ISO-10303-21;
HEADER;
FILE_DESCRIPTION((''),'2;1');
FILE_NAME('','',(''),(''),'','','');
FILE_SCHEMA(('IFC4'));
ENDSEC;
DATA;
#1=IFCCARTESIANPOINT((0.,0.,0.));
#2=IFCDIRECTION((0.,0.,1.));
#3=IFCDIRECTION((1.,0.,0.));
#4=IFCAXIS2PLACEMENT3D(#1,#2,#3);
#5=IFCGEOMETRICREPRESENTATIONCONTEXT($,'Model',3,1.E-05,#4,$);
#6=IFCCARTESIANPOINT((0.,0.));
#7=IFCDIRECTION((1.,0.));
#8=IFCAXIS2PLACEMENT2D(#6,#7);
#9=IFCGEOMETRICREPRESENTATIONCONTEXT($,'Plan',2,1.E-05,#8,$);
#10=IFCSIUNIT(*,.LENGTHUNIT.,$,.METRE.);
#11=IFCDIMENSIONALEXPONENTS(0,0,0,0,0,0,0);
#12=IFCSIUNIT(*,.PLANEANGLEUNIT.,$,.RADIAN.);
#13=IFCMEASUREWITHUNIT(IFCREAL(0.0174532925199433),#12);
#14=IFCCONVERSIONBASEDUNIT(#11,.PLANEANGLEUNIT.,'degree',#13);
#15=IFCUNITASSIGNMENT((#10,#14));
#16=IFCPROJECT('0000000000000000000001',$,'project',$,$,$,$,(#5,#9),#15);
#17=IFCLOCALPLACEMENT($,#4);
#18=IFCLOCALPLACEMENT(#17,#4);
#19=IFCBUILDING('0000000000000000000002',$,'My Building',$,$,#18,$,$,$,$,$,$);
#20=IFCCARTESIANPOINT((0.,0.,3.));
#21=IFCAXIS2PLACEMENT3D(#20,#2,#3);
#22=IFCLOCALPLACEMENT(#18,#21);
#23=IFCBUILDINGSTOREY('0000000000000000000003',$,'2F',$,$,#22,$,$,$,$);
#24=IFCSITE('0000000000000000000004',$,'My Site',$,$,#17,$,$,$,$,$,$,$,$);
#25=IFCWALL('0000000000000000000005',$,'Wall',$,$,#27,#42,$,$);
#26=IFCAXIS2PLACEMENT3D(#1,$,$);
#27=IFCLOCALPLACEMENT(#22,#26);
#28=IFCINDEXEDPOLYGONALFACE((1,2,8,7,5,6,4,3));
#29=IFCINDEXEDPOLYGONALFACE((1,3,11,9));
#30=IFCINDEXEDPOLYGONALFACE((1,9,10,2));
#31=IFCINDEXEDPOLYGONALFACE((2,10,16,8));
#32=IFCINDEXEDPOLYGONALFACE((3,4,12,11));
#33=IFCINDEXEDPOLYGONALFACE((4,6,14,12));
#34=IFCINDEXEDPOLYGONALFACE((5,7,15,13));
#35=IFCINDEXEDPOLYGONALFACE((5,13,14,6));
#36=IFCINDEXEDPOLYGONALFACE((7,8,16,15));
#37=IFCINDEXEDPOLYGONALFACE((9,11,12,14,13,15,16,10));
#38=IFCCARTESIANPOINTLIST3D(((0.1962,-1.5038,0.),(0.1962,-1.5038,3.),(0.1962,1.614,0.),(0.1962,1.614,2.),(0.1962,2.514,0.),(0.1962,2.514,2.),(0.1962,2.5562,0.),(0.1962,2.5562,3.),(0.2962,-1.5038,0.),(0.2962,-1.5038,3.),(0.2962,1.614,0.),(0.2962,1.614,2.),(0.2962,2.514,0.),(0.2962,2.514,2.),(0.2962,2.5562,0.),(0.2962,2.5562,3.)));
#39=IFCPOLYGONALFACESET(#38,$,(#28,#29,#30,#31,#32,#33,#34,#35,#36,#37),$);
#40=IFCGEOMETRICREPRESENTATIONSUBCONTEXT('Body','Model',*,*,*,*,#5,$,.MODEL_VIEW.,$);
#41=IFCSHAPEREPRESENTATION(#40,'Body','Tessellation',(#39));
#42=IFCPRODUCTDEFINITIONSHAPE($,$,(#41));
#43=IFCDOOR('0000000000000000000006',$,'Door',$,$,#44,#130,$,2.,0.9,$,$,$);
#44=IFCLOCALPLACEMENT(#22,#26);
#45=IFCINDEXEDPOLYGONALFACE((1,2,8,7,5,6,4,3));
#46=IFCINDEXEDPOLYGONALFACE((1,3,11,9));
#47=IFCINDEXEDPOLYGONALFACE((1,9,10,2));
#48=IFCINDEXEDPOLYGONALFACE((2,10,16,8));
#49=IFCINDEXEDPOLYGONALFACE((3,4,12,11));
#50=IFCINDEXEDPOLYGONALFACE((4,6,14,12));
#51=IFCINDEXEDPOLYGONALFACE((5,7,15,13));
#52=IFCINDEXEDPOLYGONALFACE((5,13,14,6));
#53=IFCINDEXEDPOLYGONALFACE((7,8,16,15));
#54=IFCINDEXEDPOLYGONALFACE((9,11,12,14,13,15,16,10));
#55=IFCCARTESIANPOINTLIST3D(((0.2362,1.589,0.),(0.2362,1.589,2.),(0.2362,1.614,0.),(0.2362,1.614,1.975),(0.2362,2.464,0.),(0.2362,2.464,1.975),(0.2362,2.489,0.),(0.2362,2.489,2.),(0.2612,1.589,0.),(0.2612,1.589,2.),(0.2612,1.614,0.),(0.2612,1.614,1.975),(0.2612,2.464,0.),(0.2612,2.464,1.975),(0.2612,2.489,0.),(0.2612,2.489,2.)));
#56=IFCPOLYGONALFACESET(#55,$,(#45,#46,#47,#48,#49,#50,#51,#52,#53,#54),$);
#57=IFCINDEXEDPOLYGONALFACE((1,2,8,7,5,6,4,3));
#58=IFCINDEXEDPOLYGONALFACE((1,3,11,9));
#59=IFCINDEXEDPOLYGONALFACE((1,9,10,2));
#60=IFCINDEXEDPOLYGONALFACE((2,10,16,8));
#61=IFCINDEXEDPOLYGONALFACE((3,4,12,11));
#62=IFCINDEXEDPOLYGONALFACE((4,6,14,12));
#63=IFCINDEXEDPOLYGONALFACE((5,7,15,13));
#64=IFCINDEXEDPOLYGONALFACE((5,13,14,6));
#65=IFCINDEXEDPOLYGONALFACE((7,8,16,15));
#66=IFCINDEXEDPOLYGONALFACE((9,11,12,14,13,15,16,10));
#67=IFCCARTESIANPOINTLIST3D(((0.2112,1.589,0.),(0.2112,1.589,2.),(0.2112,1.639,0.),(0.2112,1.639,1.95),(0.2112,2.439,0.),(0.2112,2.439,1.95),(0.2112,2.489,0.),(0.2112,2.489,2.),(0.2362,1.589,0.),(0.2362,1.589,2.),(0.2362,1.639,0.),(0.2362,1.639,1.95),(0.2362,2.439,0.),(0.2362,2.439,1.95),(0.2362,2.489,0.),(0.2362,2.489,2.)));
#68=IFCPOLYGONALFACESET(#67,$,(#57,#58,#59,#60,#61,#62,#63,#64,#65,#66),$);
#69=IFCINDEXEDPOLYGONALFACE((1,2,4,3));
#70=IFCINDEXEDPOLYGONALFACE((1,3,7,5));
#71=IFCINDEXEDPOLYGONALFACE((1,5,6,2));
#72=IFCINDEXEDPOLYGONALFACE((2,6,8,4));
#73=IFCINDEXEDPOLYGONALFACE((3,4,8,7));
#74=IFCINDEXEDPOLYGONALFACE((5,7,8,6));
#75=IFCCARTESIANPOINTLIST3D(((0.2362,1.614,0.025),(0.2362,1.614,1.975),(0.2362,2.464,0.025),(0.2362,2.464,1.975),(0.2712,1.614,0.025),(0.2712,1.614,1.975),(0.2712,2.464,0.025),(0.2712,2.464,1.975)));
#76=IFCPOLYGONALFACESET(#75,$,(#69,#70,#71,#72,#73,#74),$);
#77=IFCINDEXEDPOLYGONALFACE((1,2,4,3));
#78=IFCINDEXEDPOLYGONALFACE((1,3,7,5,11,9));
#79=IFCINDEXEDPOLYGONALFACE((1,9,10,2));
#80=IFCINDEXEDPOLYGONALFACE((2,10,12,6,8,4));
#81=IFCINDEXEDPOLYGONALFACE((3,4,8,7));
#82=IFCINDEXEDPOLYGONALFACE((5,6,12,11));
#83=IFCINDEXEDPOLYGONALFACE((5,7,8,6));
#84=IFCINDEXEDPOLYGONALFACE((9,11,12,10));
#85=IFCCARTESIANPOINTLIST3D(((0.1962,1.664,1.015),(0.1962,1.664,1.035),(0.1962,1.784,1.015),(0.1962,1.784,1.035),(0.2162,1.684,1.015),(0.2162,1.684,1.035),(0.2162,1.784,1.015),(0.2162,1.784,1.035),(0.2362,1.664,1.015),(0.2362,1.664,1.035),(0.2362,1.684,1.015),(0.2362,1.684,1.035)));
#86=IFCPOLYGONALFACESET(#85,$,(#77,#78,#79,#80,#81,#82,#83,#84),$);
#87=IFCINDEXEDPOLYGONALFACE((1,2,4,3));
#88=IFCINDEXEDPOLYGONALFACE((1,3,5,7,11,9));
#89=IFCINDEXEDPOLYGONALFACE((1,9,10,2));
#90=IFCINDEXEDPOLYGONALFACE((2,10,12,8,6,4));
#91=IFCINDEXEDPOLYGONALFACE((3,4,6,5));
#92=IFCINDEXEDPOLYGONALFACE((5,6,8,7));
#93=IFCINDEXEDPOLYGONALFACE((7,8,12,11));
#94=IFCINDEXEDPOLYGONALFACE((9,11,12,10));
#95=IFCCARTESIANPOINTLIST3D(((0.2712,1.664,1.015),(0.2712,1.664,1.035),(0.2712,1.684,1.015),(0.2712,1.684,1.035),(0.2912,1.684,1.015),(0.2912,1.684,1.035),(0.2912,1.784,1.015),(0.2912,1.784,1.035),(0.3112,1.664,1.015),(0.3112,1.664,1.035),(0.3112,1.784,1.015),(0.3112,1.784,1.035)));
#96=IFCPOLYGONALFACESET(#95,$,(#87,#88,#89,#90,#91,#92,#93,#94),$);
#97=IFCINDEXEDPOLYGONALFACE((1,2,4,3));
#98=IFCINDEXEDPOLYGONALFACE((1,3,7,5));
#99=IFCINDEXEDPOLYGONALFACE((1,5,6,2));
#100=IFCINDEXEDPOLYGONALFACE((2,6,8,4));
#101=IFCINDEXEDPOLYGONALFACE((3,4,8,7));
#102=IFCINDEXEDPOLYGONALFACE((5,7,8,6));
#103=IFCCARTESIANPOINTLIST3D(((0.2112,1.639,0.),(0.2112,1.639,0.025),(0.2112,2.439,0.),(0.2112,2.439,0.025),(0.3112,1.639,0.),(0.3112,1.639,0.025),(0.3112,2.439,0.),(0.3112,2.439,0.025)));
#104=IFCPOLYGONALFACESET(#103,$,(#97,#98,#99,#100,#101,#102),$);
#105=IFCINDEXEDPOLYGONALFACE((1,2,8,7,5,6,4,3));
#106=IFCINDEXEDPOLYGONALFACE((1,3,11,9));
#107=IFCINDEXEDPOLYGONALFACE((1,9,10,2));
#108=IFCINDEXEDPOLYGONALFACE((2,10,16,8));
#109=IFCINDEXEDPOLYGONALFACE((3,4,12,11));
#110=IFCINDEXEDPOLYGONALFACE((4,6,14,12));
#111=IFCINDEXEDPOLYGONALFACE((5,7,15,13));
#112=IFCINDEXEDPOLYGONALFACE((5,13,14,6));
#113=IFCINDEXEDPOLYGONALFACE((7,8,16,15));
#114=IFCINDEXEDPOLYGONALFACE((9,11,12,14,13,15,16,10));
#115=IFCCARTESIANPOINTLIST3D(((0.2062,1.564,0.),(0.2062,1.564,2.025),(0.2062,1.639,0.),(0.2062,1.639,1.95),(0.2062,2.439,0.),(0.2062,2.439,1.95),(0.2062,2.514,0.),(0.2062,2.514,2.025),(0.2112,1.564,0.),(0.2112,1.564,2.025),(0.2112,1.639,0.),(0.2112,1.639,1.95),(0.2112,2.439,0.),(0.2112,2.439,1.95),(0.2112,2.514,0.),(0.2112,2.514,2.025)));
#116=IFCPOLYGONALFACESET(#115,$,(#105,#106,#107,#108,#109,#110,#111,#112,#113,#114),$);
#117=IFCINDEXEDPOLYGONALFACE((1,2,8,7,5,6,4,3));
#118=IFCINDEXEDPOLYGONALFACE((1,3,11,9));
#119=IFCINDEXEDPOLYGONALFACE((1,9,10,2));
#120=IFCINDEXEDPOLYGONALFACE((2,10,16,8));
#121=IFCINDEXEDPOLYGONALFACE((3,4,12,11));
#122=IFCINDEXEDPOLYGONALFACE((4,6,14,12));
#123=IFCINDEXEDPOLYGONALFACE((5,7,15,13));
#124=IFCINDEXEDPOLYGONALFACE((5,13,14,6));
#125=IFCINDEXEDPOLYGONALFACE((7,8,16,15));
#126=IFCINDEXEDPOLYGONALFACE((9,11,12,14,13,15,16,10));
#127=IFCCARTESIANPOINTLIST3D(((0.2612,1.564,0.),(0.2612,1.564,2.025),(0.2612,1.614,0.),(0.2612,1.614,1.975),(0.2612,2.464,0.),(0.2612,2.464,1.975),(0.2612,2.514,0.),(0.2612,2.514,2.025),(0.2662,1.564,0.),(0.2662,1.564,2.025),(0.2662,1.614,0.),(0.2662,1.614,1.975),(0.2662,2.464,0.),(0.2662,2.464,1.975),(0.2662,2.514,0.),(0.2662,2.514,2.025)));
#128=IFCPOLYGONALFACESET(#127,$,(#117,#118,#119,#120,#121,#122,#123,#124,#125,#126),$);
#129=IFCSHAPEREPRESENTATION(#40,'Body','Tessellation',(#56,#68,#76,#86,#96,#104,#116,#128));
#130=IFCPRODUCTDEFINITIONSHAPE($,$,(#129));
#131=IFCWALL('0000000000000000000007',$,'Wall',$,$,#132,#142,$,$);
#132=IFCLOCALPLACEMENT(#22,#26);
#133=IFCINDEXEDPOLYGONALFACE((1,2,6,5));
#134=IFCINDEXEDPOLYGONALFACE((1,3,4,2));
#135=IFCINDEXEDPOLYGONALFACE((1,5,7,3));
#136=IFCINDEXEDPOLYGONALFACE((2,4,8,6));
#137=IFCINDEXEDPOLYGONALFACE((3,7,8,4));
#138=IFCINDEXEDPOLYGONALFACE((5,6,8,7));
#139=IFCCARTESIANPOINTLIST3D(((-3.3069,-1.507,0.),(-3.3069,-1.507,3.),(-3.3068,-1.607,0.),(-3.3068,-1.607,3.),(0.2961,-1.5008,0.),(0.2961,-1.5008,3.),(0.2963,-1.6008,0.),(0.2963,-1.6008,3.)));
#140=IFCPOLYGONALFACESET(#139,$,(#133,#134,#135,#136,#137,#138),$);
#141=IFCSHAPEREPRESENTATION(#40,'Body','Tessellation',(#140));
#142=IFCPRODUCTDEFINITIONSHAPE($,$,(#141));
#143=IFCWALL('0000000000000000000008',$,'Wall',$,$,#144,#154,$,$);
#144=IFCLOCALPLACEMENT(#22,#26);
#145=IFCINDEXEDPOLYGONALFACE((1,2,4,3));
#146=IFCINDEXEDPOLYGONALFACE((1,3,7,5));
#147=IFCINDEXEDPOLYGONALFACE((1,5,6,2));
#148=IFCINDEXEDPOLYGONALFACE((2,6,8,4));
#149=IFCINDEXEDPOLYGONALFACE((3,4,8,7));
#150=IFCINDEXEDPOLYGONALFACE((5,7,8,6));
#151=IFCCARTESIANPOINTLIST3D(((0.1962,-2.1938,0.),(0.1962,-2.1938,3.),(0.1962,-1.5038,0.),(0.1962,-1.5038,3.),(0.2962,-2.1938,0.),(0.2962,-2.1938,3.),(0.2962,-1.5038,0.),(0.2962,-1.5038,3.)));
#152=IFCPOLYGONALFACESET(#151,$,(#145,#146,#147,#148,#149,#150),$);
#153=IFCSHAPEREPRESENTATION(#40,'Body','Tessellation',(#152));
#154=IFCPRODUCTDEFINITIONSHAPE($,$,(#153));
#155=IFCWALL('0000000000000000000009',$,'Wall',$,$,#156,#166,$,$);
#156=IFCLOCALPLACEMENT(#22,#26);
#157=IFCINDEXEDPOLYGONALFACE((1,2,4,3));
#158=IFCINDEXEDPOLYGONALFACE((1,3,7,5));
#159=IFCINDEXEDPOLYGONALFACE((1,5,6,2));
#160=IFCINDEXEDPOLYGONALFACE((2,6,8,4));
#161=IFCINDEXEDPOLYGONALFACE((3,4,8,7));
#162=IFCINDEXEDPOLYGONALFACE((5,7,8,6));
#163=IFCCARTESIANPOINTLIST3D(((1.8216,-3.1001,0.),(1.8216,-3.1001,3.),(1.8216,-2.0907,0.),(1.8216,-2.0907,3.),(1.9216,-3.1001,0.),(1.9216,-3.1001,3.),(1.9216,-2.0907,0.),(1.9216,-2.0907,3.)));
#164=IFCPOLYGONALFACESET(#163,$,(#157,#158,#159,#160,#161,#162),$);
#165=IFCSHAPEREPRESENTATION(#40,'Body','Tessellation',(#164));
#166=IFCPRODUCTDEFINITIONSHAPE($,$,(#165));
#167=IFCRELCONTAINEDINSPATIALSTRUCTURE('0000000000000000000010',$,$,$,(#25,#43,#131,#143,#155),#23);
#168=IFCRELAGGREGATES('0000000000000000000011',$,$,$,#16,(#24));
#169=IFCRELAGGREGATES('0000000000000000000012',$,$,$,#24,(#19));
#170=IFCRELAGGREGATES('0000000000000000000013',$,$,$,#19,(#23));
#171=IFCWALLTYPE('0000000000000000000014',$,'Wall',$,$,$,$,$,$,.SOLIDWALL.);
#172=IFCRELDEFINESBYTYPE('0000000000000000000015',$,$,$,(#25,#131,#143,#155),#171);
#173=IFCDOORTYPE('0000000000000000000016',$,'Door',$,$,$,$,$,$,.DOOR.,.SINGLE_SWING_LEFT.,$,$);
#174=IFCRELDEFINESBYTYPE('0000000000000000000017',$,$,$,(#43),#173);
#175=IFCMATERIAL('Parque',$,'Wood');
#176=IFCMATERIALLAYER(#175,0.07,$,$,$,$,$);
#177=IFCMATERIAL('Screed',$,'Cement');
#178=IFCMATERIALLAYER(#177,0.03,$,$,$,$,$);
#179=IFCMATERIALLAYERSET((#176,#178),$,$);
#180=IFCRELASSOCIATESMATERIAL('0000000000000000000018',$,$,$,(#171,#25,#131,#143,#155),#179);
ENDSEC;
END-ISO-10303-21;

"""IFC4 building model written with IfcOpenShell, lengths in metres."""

from ifc_helpers import new_model, entity, si_unit, converted_unit, frame, origin_with_axes, origin_2d_with_axis, place, context, subcontext, project, spatial, line, indexed_curve, outline, extrude, shape, source, transform, mapped, material, layer, layer_set, layer_usage, type_object, type_shapes, element, fill, save


model = new_model("IFC4")

# Units and contexts
model_context = context("Model", 3, precision=1e-05, world=origin_with_axes())
plan_context = context("Plan", 2, precision=1e-05, world=origin_2d_with_axis())
body_context_1 = subcontext(model_context, "Body", "Model", "MODEL_VIEW")
body_context_2 = subcontext(plan_context, "Body", "Plan", "PLAN_VIEW")
ifc_project = project(units=[si_unit("LENGTHUNIT", "METRE"), converted_unit("PLANEANGLEUNIT", "degree", entity("IfcReal", 0.0174532925199433), si_unit("PLANEANGLEUNIT", "RADIAN"), dimensions=[0, 0, 0, 0, 0, 0, 0])], contexts=[model_context, plan_context])

# Site, building, storey
site_placement = place(None, origin_with_axes())
site = spatial("IfcSite", under=ifc_project, at=site_placement, Name="My Site")
building_placement = place(site_placement, origin_with_axes())
building = spatial("IfcBuilding", under=site, at=building_placement, Name="My Building")
storey_placement = place(building_placement, frame((0.0, 0.0, 3.0), z_axis=(0.0, 0.0, 1.0), x_axis=(1.0, 0.0, 0.0)))
storey = spatial("IfcBuildingStorey", under=building, at=storey_placement, Name="2F")

# Shared definitions
ifc_material_1 = material(Name="Parque", Category="Wood")
ifc_layer_1 = layer(ifc_material_1, 0.07)
ifc_material_2 = material(Name="Screed", Category="Cement")
ifc_layer_2 = layer(ifc_material_2, 0.03)
ifc_layer_set_1 = layer_set([ifc_layer_1, ifc_layer_2])
wall_type = type_object("IfcWallType", Name="Wall", PredefinedType="SOLIDWALL", material=ifc_layer_set_1)

# Wall, opening, door
ifc_layer_usage_1 = layer_usage(ifc_layer_set_1, "AXIS2", "POSITIVE", 0.0)
wall_1_placement = place(storey_placement, frame((0.2962, -1.5038, 0.0), z_axis=(0.0, 0.0, 1.0), x_axis=(0.0, 1.0, 0.0)))
wall_1 = element("IfcWall", 1, at=wall_1_placement, inside=storey, type_object=wall_type, material=ifc_layer_usage_1, Name="Wall", context=body_context_1, shape_type="SweptSolid", body=[
    extrude(outline(indexed_curve([(0.0, 0.0), (0.0, 0.1), (4.06, 0.1), (4.06, 0.0)], segments=[line(1, 2, 3, 4, 1)])), origin_with_axes(), (0.0, 0.0, 1.0), 3.0),
])
shared_shape_1 = source(origin_with_axes(), body_context_1, "Body", "SweptSolid", [
    extrude(outline(indexed_curve([(0.0, 0.0), (0.9, 0.0), (0.9, 2.0), (0.0, 2.0)], segments=[line(1, 2, 3, 4, 1)])), frame((0.0, -0.6, 0.0), z_axis=(0.0, -1.0, 0.0), x_axis=(1.0, 0.0, 0.0)), (0.0, 0.0, -1.0), 1.2),
])
opening_1_placement = place(wall_1_placement, frame((3.1178, 0.0, 0.0), z_axis=(0.0, 0.0, 1.0), x_axis=(1.0, 0.0, 0.0)))
opening_1 = element("IfcOpeningElement", 2, at=opening_1_placement, cuts=wall_1, PredefinedType="OPENING", context=body_context_1, shape_type="MappedRepresentation", body=[
    mapped(shared_shape_1, transform((0.0, 0.0, 0.0), x_axis=(1.0, 0.0, 0.0), y_axis=(0.0, 1.0, 0.0), z_axis=(0.0, 0.0, 1.0), scale=1.0)),
])
door_type_1 = type_object("IfcDoorType", Name="Door", OperationType="SINGLE_SWING_LEFT", PredefinedType="DOOR")
shared_shape_2 = source(origin_with_axes(), body_context_1, "Body", "SweptSolid", [
    extrude(outline(indexed_curve([(0.0, 0.0), (0.0, 2.0), (0.9, 2.0), (0.9, 0.0), (0.875, 0.0), (0.875, 1.975), (0.025, 1.975), (0.025, 0.0)], segments=[line(1, 2, 3, 4, 5, 6, 7, 8, 1)])), frame((0.0, 0.025, 0.0), z_axis=(0.0, -1.0, 0.0), x_axis=(1.0, 0.0, 0.0)), (0.0, 0.0, -1.0), 0.025),
    extrude(outline(indexed_curve([(0.0, 0.0), (0.0, 2.0), (0.9, 2.0), (0.9, 0.0), (0.85, 0.0), (0.85, 1.95), (0.05, 1.95), (0.05, 0.0)], segments=[line(1, 2, 3, 4, 5, 6, 7, 8, 1)])), frame((0.0, 0.0, 0.0), z_axis=(0.0, -1.0, 0.0), x_axis=(1.0, 0.0, 0.0)), (0.0, 0.0, -1.0), 0.025),
    extrude(outline(indexed_curve([(0.0, 0.0), (0.85, 0.0), (0.85, 0.035), (0.0, 0.035)], segments=[line(1, 2, 3, 4, 1)])), frame((0.025, 0.025, 0.025), z_axis=(0.0, 0.0, 1.0), x_axis=(1.0, 0.0, 0.0)), (0.0, 0.0, 1.0), 1.95),
    extrude(outline(indexed_curve([(0.0, 0.0), (0.0, -0.04), (-0.12, -0.04), (-0.12, -0.02), (-0.02, -0.02), (-0.02, 0.0)], segments=[line(1, 2, 3, 4, 5, 6, 1)])), frame((0.825, 0.025, 1.015), z_axis=(0.0, 0.0, 1.0), x_axis=(1.0, 0.0, 0.0)), (0.0, 0.0, 1.0), 0.02),
    extrude(outline(indexed_curve([(0.0, 0.0), (0.0, 0.04), (-0.12, 0.04), (-0.12, 0.02), (-0.02, 0.02), (-0.02, 0.0)], segments=[line(1, 2, 3, 4, 5, 6, 1)])), frame((0.825, 0.06, 1.015), z_axis=(0.0, 0.0, 1.0), x_axis=(1.0, 0.0, 0.0)), (0.0, 0.0, 1.0), 0.02),
    extrude(outline(indexed_curve([(0.0, 0.0), (0.8, 0.0), (0.8, 0.1), (0.0, 0.1)], segments=[line(1, 2, 3, 4, 1)])), frame((0.05, 0.0, 0.0), z_axis=(0.0, 0.0, 1.0), x_axis=(1.0, 0.0, 0.0)), (0.0, 0.0, 1.0), 0.025),
    extrude(outline(indexed_curve([(0.0, 0.0), (0.0, 2.025), (0.95, 2.025), (0.95, 0.0), (0.875, 0.0), (0.875, 1.95), (0.075, 1.95), (0.075, 0.0)], segments=[line(1, 2, 3, 4, 5, 6, 7, 8, 1)])), frame((-0.025, -0.005, 0.0), z_axis=(0.0, -1.0, 0.0), x_axis=(1.0, 0.0, 0.0)), (0.0, 0.0, -1.0), 0.005),
    extrude(outline(indexed_curve([(0.0, 0.0), (0.0, 2.025), (0.95, 2.025), (0.95, 0.0), (0.9, 0.0), (0.9, 1.975), (0.05, 1.975), (0.05, 0.0)], segments=[line(1, 2, 3, 4, 5, 6, 7, 8, 1)])), frame((-0.025, 0.05, 0.0), z_axis=(0.0, -1.0, 0.0), x_axis=(1.0, 0.0, 0.0)), (0.0, 0.0, -1.0), 0.005),
])
shared_shape_3 = source(origin_with_axes(), body_context_2, "Body", "Curve2D", [
    entity("IfcIndexedPolyCurve", entity("IfcCartesianPointList2D", [[0.0, 0.0], [0.0, 0.05], [0.025, 0.05], [0.025, 0.025], [0.05, 0.025], [0.05, 0.0]]), [entity("IfcLineIndex", [1, 2, 3, 4, 5, 6, 1])]),
    entity("IfcIndexedPolyCurve", entity("IfcCartesianPointList2D", [[0.9, 0.0], [0.9, 0.05], [0.875, 0.05], [0.875, 0.025], [0.85, 0.025], [0.85, 0.0]]), [entity("IfcLineIndex", [1, 2, 3, 4, 5, 6, 1])]),
    entity("IfcTrimmedCurve", entity("IfcEllipse", entity("IfcAxis2Placement2D", entity("IfcCartesianPoint", [0.06, 0.05]), entity("IfcDirection", [1.0, 0.0])), 0.815, 0.85), [entity("IfcCartesianPoint", [0.875, 0.05])], [entity("IfcCartesianPoint", [0.06, 0.9])], True, "CARTESIAN"),
    entity("IfcIndexedPolyCurve", entity("IfcCartesianPointList2D", [[0.025, 0.05], [0.06, 0.05], [0.06, 0.9], [0.025, 0.9]]), [entity("IfcLineIndex", [1, 2, 3, 4, 1])]),
])
type_shapes(door_type_1, [shared_shape_2, shared_shape_3])
door_1_placement = place(opening_1_placement, frame((0.875, 0.085, 0.0), z_axis=(0.0, 0.0, 1.0), x_axis=(-1.0, 0.0, 0.0)))
door_1 = element("IfcDoor", 3, at=door_1_placement, inside=storey, type_object=door_type_1, Name="Door", OverallHeight=2.0, OverallWidth=0.9, shapes=[
    shape(body_context_1, "Body", "MappedRepresentation", [mapped(shared_shape_2, transform((0.0, 0.0, 0.0), x_axis=(1.0, 0.0, 0.0), y_axis=(0.0, 1.0, 0.0), z_axis=(0.0, 0.0, 1.0), scale=1.0))]),
    shape(body_context_2, "Body", "MappedRepresentation", [mapped(shared_shape_3, transform((0.0, 0.0, 0.0), x_axis=(1.0, 0.0, 0.0), y_axis=(0.0, 1.0, 0.0), z_axis=(0.0, 0.0, 1.0), scale=1.0))]),
])
fill(opening_1, door_1)

# Walls
ifc_layer_usage_2 = layer_usage(ifc_layer_set_1, "AXIS2", "POSITIVE", 0.0)
wall_2_placement = place(storey_placement, frame((-3.3068, -1.607, 0.0), z_axis=(0.0, 0.0, 1.0), x_axis=(0.999999, 0.001712, 0.0)))
element("IfcWall", 4, at=wall_2_placement, inside=storey, type_object=wall_type, material=ifc_layer_usage_2, Name="Wall", context=body_context_1, shape_type="SweptSolid", body=[
    extrude(outline(indexed_curve([(0.0, 0.0), (0.0, 0.1), (3.6031, 0.1), (3.6031, 0.0)], segments=[line(1, 2, 3, 4, 1)])), origin_with_axes(), (0.0, 0.0, 1.0), 3.0),
])
ifc_layer_usage_3 = layer_usage(ifc_layer_set_1, "AXIS2", "POSITIVE", 0.0)
wall_3_placement = place(storey_placement, frame((0.1962, -1.5038, 0.0), z_axis=(0.0, 0.0, 1.0), x_axis=(0.0, -1.0, 0.0)))
element("IfcWall", 5, at=wall_3_placement, inside=storey, type_object=wall_type, material=ifc_layer_usage_3, Name="Wall", context=body_context_1, shape_type="SweptSolid", body=[
    extrude(outline(indexed_curve([(0.0, 0.0), (0.0, 0.1), (0.69, 0.1), (0.69, 0.0)], segments=[line(1, 2, 3, 4, 1)])), origin_with_axes(), (0.0, 0.0, 1.0), 3.0),
])
ifc_layer_usage_4 = layer_usage(ifc_layer_set_1, "AXIS2", "POSITIVE", 0.0)
wall_4_placement = place(storey_placement, frame((1.9216, -3.1001, 0.0), z_axis=(0.0, 0.0, 1.0), x_axis=(0.000002, 1.0, 0.0)))
element("IfcWall", 6, at=wall_4_placement, inside=storey, type_object=wall_type, material=ifc_layer_usage_4, Name="Wall", context=body_context_1, shape_type="SweptSolid", body=[
    extrude(outline(indexed_curve([(0.0, 0.0), (0.0, 0.1), (1.0094, 0.1), (1.0094, 0.0)], segments=[line(1, 2, 3, 4, 1)])), origin_with_axes(), (0.0, 0.0, 1.0), 3.0),
])

save(model, "model.ifc")
